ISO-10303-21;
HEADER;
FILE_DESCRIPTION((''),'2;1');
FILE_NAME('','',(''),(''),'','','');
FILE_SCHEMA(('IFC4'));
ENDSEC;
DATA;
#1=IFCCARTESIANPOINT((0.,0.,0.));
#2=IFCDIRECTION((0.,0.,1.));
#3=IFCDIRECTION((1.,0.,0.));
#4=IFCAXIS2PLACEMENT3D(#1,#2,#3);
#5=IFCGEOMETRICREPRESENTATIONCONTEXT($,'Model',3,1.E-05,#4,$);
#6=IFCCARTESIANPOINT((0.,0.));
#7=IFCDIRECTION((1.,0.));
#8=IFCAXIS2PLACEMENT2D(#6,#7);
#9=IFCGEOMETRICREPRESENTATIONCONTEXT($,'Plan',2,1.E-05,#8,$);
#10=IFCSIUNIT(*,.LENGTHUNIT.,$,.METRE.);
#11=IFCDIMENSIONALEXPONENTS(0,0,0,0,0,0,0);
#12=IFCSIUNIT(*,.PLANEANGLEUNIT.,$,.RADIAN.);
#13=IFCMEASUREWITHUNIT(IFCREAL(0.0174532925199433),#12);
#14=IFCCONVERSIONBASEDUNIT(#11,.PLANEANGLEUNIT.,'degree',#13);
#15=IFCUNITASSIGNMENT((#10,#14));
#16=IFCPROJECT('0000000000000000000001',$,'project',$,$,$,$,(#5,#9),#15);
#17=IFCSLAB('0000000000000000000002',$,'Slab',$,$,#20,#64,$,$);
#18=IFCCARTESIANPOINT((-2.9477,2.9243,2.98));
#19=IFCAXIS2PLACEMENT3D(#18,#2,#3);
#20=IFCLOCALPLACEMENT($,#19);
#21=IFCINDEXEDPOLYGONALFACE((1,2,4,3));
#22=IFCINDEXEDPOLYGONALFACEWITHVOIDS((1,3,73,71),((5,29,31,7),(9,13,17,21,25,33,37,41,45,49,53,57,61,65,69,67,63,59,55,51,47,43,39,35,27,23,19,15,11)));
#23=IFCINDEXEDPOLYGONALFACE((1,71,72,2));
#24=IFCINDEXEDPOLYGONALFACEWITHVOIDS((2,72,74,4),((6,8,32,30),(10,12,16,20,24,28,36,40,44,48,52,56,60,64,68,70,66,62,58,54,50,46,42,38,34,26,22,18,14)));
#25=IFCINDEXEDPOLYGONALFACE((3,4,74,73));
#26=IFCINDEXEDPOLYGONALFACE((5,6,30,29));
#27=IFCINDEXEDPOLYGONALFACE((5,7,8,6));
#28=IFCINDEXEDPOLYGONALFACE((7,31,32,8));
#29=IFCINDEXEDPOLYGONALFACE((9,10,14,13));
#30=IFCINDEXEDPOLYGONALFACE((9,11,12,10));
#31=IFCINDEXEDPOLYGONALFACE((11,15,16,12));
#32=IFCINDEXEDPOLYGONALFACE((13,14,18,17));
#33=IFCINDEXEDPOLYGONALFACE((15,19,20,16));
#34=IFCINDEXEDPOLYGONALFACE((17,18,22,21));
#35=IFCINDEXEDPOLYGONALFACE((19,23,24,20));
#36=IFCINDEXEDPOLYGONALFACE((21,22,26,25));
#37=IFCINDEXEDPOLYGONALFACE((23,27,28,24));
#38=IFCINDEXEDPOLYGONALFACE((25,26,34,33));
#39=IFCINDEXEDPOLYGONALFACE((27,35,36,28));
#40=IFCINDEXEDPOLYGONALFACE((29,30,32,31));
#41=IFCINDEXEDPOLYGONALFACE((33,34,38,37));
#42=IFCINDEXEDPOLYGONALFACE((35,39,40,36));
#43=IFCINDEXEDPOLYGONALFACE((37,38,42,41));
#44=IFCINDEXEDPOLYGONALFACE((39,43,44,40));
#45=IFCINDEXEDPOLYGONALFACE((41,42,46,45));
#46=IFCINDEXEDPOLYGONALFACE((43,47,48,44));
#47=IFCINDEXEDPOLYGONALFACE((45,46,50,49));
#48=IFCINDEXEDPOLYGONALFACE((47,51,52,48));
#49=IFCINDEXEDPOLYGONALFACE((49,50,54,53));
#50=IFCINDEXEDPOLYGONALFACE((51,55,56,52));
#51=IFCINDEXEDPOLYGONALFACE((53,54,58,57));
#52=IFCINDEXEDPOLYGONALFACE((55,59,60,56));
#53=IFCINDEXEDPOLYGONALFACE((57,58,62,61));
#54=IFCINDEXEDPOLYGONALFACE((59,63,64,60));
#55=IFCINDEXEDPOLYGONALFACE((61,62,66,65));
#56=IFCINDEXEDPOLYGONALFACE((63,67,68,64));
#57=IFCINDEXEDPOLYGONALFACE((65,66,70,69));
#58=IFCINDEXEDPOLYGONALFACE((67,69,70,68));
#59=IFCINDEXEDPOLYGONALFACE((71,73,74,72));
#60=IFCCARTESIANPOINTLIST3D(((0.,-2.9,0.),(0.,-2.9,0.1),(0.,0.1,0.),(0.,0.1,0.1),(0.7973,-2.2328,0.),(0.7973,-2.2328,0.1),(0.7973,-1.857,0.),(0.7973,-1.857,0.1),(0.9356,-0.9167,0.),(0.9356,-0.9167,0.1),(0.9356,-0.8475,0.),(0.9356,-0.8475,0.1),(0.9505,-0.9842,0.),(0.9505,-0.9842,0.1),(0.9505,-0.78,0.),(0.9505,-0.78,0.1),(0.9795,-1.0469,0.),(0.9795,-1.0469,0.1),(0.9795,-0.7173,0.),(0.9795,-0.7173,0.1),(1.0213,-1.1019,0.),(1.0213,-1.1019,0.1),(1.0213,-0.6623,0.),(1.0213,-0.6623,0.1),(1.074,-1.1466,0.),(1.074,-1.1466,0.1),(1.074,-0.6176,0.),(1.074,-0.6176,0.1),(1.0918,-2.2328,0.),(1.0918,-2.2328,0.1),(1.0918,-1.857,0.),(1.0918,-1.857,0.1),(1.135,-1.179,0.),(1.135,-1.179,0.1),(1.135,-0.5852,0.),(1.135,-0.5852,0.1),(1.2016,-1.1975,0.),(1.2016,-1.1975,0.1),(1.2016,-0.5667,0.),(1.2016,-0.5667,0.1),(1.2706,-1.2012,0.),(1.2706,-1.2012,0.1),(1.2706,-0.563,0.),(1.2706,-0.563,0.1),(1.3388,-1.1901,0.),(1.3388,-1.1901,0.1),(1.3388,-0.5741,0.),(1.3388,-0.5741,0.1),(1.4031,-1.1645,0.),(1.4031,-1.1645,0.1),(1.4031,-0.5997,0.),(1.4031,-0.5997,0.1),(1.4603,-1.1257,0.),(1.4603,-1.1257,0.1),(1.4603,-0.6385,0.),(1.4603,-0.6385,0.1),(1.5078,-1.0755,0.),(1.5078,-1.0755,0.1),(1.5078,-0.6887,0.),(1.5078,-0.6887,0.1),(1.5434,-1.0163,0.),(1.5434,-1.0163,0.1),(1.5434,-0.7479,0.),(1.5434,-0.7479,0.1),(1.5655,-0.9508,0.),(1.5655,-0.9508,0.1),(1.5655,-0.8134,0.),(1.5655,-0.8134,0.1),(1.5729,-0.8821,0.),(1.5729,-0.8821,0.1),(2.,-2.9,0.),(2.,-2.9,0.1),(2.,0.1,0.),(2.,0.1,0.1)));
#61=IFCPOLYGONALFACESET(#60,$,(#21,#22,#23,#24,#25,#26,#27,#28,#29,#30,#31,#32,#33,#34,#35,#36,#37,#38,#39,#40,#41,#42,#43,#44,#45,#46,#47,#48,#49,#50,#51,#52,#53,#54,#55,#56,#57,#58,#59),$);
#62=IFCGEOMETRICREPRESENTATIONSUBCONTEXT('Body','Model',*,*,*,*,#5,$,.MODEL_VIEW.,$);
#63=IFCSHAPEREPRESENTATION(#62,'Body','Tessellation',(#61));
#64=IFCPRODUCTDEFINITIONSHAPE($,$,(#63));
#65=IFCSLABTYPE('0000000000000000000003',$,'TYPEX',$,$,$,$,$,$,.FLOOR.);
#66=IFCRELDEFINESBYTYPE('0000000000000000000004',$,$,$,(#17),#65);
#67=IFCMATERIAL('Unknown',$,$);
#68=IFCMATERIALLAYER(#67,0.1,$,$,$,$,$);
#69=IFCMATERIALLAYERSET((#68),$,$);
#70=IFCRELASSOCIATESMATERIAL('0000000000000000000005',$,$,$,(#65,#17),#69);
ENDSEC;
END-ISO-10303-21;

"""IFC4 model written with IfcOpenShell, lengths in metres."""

from ifc_helpers import new_model, entity, si_unit, converted_unit, frame, frame_2d, origin_with_axes, origin_2d_with_axis, place, context, subcontext, project, line, indexed_curve, circle_curve, outline, extrude, material, layer, layer_set, layer_usage, type_object, element, save


model = new_model("IFC4")

# Units and contexts
model_context = context("Model", 3, precision=1e-05, world=origin_with_axes())
plan_context = context("Plan", 2, precision=1e-05, world=origin_2d_with_axis())
body_context = subcontext(model_context, "Body", "Model", "MODEL_VIEW")
ifc_project = project(units=[si_unit("LENGTHUNIT", "METRE"), converted_unit("PLANEANGLEUNIT", "degree", entity("IfcReal", 0.0174532925199433), si_unit("PLANEANGLEUNIT", "RADIAN"), dimensions=[0, 0, 0, 0, 0, 0, 0])], contexts=[model_context, plan_context])

# Shared definitions
ifc_material = material(Name="Unknown")

# Slab
ifc_layer = layer(ifc_material, 0.1)
ifc_layer_set = layer_set([ifc_layer])
ifc_layer_usage = layer_usage(ifc_layer_set, "AXIS3", "POSITIVE", 0.0)
slab_type = type_object("IfcSlabType", Name="TYPEX", PredefinedType="FLOOR", material=ifc_layer_set)
slab_placement = place(None, frame((-2.9477, 2.9243, 2.98), z_axis=(0.0, 0.0, 1.0), x_axis=(1.0, 0.0, 0.0)))
element("IfcSlab", 1, at=slab_placement, type_object=slab_type, material=ifc_layer_usage, Name="Slab", context=body_context, shape_type="SweptSolid", body=[
    extrude(outline(indexed_curve([(2.0, -2.9), (2.0, 0.1), (0.0, 0.1), (0.0, -2.9), (0.7973, -2.2328), (1.0918, -2.2328), (1.0918, -1.857), (0.7973, -1.857), (1.2533, -1.2017), (1.2533, -0.5625)], segments=[line(4, 3), line(3, 2), line(2, 1), line(1, 4)], self_intersect=False), holes=[indexed_curve([(2.0, -2.9), (2.0, 0.1), (0.0, 0.1), (0.0, -2.9), (0.7973, -2.2328), (1.0918, -2.2328), (1.0918, -1.857), (0.7973, -1.857), (1.2533, -1.2017), (1.2533, -0.5625)], segments=[line(8, 7), line(7, 6), line(6, 5), line(5, 8)], self_intersect=False), circle_curve(frame_2d((1.2533, -0.8821)), 0.3196)]), None, (0.0, 0.0, 1.0), 0.1),
])

save(model, "model.ifc")
